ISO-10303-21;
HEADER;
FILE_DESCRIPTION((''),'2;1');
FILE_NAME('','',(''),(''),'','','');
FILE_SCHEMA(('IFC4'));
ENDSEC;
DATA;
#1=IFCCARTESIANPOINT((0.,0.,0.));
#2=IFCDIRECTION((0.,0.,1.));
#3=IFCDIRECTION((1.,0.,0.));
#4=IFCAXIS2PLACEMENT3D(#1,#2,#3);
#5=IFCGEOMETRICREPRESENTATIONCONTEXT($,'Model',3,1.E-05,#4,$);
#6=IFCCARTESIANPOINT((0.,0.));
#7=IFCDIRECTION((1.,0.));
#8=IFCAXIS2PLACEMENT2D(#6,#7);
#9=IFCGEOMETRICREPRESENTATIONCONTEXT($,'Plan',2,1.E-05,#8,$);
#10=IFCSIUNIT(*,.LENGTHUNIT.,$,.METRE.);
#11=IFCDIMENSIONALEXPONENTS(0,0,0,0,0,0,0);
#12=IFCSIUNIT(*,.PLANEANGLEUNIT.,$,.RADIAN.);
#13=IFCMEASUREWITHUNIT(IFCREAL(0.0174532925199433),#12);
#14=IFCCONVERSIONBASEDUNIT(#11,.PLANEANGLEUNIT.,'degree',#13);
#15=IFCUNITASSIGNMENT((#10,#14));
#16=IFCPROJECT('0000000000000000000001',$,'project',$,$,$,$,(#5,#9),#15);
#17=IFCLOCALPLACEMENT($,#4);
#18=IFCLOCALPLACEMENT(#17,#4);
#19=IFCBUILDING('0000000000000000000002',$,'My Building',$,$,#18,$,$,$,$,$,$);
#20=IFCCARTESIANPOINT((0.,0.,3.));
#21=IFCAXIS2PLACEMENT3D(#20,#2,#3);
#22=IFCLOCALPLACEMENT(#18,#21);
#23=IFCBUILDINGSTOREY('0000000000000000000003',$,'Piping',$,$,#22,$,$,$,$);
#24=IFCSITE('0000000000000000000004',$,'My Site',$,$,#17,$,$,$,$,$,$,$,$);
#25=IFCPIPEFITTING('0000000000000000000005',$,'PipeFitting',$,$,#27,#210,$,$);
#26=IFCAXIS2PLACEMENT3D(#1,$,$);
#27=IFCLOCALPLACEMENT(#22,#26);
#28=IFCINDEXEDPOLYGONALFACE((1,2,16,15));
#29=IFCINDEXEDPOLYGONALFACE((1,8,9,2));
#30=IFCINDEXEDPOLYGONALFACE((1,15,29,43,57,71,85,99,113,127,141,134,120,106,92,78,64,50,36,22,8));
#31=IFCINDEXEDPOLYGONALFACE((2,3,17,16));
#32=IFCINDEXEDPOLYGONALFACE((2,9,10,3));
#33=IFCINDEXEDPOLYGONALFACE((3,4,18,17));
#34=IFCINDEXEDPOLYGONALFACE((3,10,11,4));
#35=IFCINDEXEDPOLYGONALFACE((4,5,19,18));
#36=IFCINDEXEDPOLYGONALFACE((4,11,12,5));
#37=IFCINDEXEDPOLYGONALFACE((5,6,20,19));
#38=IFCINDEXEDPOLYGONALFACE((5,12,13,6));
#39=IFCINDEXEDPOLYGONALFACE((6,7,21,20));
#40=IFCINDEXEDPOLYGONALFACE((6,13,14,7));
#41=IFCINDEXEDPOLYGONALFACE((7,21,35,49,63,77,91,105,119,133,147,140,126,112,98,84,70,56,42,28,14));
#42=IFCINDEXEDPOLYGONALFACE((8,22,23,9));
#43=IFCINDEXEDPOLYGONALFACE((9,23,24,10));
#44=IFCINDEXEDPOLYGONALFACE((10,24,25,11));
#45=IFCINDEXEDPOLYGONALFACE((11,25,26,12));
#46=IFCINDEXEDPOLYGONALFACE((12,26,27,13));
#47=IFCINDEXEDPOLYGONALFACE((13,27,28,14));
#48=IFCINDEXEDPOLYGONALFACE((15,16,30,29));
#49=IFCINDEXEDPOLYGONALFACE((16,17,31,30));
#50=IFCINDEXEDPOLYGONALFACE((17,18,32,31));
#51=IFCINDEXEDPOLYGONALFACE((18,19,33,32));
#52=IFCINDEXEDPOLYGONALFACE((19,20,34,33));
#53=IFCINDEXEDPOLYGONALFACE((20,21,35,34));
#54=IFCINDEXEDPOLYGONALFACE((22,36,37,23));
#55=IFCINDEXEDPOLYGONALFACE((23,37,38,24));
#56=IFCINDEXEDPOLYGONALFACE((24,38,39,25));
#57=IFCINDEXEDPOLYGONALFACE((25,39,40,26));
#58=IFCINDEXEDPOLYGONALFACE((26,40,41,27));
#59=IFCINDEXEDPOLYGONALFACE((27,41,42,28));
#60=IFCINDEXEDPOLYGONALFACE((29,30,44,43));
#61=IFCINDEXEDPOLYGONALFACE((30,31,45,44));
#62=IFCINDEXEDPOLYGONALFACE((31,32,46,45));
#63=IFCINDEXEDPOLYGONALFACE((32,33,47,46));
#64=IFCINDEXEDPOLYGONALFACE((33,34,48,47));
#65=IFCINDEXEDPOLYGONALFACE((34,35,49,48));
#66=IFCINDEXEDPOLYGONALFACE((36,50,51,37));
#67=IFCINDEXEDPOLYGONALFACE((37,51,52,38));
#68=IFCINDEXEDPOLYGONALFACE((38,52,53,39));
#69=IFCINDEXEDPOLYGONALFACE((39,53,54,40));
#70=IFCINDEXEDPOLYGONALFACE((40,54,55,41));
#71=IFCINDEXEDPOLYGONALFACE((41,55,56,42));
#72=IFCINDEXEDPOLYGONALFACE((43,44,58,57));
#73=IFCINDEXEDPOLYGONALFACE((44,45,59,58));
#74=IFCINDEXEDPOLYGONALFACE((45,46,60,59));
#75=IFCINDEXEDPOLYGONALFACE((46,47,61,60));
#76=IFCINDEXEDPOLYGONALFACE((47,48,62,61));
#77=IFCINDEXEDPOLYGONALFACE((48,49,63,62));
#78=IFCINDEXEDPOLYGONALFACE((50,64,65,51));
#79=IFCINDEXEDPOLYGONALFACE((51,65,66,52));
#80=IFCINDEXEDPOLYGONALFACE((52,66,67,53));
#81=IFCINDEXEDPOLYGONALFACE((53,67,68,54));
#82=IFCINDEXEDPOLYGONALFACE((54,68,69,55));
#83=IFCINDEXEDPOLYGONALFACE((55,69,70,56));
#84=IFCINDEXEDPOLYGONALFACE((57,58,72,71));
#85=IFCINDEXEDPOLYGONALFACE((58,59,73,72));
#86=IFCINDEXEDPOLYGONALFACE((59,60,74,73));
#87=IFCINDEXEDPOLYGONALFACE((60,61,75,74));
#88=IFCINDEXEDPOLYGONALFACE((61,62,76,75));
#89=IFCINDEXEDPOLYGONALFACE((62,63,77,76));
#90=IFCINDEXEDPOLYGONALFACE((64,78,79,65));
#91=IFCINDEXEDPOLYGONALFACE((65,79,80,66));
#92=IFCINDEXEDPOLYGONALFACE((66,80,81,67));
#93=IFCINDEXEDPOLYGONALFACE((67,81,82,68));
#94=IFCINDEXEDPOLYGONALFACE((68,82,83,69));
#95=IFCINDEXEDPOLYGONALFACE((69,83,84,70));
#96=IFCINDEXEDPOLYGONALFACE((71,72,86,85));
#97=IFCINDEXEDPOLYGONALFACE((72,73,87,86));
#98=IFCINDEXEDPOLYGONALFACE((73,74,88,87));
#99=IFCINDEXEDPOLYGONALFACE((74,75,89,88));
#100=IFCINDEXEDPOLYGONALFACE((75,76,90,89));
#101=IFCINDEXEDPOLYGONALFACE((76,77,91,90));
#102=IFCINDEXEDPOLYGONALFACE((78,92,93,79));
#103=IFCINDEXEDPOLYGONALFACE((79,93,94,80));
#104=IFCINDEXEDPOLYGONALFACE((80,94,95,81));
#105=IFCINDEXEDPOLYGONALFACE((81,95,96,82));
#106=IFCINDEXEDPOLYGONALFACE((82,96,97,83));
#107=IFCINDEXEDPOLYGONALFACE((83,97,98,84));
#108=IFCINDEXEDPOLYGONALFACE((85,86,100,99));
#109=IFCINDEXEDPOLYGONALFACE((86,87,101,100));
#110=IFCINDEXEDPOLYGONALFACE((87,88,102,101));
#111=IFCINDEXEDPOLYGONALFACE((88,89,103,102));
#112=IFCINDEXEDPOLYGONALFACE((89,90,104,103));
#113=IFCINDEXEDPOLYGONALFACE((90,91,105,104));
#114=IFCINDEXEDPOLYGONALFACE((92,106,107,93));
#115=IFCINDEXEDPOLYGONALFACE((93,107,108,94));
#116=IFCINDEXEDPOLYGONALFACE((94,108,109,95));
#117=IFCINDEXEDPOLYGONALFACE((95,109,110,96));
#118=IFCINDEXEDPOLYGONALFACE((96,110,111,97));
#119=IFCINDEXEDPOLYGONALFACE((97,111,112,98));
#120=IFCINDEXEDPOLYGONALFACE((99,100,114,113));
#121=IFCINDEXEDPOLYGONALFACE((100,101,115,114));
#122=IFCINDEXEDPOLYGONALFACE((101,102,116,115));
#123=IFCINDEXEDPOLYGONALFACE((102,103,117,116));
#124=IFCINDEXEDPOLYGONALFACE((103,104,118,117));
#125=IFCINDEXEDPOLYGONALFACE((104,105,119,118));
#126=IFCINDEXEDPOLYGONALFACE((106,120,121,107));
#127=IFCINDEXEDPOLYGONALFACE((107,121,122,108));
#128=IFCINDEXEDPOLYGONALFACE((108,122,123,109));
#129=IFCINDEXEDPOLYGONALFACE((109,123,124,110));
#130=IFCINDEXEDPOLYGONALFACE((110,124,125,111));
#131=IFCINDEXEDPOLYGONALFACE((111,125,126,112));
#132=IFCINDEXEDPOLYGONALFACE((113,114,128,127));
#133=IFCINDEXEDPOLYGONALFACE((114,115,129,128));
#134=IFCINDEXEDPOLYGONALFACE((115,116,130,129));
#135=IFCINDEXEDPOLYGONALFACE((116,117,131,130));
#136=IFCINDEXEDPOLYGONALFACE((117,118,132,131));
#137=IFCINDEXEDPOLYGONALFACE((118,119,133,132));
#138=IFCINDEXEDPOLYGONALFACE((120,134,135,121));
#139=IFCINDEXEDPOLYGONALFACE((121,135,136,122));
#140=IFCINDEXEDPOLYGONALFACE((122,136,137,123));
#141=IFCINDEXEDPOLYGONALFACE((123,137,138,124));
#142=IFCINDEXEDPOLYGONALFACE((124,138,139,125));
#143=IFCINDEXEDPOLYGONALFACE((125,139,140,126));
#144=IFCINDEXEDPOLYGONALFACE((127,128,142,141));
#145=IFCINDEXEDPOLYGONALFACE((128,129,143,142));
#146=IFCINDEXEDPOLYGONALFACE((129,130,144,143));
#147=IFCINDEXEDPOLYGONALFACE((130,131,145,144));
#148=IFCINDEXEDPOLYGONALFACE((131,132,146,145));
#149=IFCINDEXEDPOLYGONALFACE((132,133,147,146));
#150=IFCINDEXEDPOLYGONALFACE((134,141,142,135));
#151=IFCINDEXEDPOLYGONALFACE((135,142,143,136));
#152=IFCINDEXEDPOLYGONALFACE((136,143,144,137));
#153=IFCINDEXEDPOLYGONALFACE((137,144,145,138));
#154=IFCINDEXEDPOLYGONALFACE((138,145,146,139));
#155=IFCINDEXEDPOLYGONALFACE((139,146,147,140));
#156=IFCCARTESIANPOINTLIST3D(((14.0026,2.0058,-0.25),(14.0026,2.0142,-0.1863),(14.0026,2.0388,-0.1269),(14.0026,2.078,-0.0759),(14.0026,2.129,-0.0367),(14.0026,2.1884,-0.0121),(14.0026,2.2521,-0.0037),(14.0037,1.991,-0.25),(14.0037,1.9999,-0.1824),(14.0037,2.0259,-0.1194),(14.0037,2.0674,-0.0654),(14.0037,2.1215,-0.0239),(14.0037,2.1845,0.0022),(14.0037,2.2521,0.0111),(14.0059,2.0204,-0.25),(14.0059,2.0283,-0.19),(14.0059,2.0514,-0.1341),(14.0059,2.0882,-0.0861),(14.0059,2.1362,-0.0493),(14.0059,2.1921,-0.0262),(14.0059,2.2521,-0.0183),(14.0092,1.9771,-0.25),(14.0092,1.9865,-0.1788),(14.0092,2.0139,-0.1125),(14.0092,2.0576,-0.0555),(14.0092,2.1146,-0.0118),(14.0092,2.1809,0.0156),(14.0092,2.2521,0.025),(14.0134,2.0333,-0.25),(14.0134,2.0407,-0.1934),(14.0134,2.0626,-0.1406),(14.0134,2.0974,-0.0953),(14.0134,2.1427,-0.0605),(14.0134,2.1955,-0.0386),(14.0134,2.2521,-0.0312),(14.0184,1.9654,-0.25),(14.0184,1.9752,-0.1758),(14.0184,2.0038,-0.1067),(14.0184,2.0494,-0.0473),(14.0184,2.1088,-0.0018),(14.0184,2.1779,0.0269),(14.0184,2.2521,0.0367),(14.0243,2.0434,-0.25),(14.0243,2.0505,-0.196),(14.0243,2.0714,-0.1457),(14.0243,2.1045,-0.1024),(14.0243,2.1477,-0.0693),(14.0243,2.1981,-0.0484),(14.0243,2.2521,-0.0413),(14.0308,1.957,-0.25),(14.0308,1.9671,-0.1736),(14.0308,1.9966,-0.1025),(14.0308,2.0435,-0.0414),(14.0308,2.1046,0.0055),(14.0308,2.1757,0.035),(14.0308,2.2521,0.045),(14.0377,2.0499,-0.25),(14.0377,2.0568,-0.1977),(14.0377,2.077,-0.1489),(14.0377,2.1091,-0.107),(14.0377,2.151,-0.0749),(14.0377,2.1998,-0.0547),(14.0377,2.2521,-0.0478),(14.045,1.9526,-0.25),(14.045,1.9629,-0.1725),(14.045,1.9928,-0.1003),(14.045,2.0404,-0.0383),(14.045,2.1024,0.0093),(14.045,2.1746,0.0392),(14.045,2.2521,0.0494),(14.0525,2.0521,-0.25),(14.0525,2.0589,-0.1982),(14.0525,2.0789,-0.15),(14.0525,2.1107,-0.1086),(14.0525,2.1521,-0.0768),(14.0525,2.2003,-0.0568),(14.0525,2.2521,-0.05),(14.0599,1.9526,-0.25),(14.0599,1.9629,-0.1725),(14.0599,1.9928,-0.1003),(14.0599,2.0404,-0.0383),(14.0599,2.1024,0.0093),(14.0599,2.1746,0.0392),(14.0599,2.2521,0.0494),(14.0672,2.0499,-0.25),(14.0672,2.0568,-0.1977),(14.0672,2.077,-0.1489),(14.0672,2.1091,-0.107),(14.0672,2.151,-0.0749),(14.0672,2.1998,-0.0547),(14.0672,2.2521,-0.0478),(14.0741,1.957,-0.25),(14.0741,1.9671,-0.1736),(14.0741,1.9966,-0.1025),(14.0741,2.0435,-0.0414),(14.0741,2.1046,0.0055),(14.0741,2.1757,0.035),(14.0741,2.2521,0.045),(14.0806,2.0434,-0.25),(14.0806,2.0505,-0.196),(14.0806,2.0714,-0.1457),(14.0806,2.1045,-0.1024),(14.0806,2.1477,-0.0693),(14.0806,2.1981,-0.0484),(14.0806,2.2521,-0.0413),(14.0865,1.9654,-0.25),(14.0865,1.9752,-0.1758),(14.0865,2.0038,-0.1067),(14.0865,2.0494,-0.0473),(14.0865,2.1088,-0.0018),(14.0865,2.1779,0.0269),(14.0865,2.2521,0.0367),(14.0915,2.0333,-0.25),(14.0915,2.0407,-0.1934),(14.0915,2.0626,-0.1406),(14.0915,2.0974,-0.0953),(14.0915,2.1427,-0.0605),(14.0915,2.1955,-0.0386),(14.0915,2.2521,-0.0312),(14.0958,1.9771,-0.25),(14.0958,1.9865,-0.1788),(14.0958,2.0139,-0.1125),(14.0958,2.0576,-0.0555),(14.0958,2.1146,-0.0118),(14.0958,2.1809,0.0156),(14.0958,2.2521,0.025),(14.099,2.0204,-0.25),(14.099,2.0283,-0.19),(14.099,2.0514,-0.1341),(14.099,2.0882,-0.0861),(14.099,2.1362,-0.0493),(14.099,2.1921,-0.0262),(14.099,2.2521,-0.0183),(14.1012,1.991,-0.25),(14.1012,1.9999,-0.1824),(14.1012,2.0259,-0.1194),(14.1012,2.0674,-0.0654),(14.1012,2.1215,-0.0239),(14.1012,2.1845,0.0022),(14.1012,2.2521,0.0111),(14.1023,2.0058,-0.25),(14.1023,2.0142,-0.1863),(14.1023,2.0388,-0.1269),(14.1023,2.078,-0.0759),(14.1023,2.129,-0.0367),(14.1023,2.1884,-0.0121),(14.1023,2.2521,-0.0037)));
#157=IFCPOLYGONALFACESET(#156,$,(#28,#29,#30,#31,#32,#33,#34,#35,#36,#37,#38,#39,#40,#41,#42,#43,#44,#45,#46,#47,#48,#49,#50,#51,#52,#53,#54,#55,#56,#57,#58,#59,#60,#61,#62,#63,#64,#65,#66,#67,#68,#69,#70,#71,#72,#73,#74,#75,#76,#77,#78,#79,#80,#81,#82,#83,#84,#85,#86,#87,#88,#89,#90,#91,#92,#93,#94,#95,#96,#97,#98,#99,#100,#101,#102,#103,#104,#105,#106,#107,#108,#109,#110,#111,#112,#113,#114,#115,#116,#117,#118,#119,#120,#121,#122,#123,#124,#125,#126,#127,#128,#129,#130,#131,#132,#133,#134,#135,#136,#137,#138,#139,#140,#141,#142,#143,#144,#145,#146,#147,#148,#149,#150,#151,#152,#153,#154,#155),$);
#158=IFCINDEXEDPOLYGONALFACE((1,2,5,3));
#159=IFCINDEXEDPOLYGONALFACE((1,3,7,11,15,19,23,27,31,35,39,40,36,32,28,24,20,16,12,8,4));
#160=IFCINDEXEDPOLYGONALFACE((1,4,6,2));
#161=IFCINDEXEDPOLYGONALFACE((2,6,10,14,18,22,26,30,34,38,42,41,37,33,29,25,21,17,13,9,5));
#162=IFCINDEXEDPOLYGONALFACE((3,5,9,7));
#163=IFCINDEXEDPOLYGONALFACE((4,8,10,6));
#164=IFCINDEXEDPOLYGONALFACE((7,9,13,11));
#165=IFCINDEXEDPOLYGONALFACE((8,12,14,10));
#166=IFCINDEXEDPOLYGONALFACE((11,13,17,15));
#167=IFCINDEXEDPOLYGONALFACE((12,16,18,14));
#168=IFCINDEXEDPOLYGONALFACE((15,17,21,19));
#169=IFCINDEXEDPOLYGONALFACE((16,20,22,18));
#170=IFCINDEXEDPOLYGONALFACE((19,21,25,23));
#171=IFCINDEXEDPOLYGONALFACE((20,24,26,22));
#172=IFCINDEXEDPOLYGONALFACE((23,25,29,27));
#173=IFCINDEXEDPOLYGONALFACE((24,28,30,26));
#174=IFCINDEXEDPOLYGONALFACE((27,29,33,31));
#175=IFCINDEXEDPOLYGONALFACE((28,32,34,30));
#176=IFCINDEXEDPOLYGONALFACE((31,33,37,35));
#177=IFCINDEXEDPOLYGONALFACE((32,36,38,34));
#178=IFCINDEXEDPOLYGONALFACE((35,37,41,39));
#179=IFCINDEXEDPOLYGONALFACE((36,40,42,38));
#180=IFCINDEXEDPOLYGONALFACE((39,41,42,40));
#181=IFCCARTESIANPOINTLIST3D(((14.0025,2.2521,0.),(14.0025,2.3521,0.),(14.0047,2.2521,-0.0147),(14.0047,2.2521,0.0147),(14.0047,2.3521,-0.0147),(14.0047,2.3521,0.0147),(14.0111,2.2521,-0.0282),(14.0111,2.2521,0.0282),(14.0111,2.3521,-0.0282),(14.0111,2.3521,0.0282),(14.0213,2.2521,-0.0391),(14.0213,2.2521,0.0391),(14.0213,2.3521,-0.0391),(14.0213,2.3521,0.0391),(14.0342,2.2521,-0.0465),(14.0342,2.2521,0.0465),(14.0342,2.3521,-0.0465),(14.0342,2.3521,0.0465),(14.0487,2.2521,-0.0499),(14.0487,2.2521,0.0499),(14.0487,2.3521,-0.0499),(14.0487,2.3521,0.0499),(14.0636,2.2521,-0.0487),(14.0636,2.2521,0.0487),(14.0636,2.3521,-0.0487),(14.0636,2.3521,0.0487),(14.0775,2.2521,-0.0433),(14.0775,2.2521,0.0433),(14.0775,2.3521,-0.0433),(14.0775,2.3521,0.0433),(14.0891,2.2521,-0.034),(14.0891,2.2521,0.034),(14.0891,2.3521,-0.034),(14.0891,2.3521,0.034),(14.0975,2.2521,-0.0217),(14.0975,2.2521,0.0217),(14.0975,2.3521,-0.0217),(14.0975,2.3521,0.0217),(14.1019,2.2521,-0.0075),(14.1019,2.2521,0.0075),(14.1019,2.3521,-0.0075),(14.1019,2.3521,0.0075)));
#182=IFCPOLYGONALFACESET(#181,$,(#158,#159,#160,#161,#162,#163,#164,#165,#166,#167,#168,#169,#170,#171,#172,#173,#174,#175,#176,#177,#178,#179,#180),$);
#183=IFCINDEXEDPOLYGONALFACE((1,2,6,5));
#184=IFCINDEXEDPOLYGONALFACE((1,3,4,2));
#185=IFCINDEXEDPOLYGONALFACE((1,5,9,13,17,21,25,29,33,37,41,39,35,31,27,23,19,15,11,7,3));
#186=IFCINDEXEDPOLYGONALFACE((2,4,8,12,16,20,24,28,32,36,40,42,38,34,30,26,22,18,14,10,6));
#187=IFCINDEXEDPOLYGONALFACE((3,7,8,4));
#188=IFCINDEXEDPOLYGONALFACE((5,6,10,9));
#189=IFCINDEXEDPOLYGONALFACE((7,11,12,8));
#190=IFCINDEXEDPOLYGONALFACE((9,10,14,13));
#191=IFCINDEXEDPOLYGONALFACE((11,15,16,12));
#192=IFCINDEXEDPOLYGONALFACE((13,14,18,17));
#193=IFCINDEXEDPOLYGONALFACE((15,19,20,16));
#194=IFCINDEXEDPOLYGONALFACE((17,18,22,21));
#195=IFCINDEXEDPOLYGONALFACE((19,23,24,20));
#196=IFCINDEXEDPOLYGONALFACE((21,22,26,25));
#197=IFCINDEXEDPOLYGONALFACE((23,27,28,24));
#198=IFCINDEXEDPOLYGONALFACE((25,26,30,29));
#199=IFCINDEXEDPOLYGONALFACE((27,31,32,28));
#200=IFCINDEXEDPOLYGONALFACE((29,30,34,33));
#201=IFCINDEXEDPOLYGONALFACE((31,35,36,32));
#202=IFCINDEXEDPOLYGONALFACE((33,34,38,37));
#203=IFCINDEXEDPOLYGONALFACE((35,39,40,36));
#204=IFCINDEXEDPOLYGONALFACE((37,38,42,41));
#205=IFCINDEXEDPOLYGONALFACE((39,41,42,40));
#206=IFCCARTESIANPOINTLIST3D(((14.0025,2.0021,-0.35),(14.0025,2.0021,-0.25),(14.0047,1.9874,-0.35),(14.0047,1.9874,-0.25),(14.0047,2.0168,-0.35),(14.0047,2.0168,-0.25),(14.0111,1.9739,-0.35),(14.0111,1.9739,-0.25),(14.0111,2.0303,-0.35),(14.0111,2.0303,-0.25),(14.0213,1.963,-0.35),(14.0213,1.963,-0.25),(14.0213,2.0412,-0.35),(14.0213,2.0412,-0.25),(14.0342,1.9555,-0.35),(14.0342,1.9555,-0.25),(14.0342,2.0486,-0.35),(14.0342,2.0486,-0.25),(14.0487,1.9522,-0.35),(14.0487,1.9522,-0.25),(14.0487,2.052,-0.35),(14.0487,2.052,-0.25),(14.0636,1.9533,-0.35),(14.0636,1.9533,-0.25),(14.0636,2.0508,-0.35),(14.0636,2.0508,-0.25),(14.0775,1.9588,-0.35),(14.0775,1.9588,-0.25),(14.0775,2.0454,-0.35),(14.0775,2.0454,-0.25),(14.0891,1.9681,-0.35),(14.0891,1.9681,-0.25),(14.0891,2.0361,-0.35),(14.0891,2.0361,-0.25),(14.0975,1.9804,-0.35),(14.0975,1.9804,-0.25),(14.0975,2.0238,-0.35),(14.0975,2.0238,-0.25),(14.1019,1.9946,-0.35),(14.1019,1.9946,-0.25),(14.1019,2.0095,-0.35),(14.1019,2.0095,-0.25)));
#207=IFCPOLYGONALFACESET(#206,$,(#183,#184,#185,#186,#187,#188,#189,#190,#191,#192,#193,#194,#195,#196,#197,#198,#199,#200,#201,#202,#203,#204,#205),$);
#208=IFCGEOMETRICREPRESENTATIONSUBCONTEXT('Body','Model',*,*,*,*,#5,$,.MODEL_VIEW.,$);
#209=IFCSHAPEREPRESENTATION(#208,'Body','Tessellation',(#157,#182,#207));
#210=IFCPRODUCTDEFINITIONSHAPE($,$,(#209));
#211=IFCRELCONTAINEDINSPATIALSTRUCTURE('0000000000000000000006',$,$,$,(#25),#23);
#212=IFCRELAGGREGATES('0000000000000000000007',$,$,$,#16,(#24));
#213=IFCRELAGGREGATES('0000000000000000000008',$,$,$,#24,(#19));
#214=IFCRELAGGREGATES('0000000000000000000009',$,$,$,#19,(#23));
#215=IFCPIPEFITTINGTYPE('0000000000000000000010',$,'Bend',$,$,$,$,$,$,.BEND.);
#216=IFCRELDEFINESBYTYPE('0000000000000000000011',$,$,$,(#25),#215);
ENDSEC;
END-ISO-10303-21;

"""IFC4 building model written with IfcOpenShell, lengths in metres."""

from ifc_helpers import new_model, entity, si_unit, converted_unit, frame, origin_with_axes, origin_2d_with_axis, place, context, subcontext, project, spatial, circle, extrude, source, transform, mapped, type_object, type_shapes, element, save


model = new_model("IFC4")

# Units and contexts
model_context = context("Model", 3, precision=1e-05, world=origin_with_axes())
plan_context = context("Plan", 2, precision=1e-05, world=origin_2d_with_axis())
body_context = subcontext(model_context, "Body", "Model", "MODEL_VIEW")
ifc_project = project(units=[si_unit("LENGTHUNIT", "METRE"), converted_unit("PLANEANGLEUNIT", "degree", entity("IfcReal", 0.0174532925199433), si_unit("PLANEANGLEUNIT", "RADIAN"), dimensions=[0, 0, 0, 0, 0, 0, 0])], contexts=[model_context, plan_context])

# Site, building, storey
site_placement = place(None, origin_with_axes())
site = spatial("IfcSite", under=ifc_project, at=site_placement, Name="My Site")
building_placement = place(site_placement, origin_with_axes())
building = spatial("IfcBuilding", under=site, at=building_placement, Name="My Building")
storey_placement = place(building_placement, frame((0.0, 0.0, 3.0), z_axis=(0.0, 0.0, 1.0), x_axis=(1.0, 0.0, 0.0)))
storey = spatial("IfcBuildingStorey", under=building, at=storey_placement, Name="Piping")

# Pipe fitting
pipe_fitting_type_1 = type_object("IfcPipeFittingType", Name="Bend", PredefinedType="BEND")
shared_shape = source(origin_with_axes(), body_context, "Body", "SolidModel", [
    entity("IfcSweptDiskSolid", entity("IfcIndexedPolyCurve", entity("IfcCartesianPointList3D", [[0.0, 0.0, -0.1], [0.0, -0.0732, -0.2768], [0.0, -0.25, -0.35]]), [entity("IfcArcIndex", [1, 2, 3])]), 0.05),
    extrude(circle(Radius=0.05), origin_with_axes(), (0.0, 0.0, -1.0), 0.1),
    extrude(circle(Radius=0.05), frame((0.0, -0.25, -0.35), z_axis=(0.0, -1.0, 0.0), x_axis=(1.0, 0.0, 0.0)), (0.0, 0.0, 1.0), 0.1),
])
type_shapes(pipe_fitting_type_1, [shared_shape])
for number, where, z_axis, x_axis, name in (
    (1, (14.0525, 2.3521, 0.0), (0.0, 1.0, 0.0), (-1.0, 0.0, 0.0), "PipeFitting"),
):
    element("IfcPipeFitting", number, at=place(storey_placement, frame(where, z_axis=z_axis, x_axis=x_axis)), inside=storey, type_object=pipe_fitting_type_1, Name=name, context=body_context, shape_type="MappedRepresentation", body=[
        mapped(shared_shape, transform((0.0, 0.0, 0.0), x_axis=(1.0, 0.0, 0.0), y_axis=(0.0, 1.0, 0.0), z_axis=(0.0, 0.0, 1.0), scale=1.0)),
    ])

save(model, "model.ifc")
